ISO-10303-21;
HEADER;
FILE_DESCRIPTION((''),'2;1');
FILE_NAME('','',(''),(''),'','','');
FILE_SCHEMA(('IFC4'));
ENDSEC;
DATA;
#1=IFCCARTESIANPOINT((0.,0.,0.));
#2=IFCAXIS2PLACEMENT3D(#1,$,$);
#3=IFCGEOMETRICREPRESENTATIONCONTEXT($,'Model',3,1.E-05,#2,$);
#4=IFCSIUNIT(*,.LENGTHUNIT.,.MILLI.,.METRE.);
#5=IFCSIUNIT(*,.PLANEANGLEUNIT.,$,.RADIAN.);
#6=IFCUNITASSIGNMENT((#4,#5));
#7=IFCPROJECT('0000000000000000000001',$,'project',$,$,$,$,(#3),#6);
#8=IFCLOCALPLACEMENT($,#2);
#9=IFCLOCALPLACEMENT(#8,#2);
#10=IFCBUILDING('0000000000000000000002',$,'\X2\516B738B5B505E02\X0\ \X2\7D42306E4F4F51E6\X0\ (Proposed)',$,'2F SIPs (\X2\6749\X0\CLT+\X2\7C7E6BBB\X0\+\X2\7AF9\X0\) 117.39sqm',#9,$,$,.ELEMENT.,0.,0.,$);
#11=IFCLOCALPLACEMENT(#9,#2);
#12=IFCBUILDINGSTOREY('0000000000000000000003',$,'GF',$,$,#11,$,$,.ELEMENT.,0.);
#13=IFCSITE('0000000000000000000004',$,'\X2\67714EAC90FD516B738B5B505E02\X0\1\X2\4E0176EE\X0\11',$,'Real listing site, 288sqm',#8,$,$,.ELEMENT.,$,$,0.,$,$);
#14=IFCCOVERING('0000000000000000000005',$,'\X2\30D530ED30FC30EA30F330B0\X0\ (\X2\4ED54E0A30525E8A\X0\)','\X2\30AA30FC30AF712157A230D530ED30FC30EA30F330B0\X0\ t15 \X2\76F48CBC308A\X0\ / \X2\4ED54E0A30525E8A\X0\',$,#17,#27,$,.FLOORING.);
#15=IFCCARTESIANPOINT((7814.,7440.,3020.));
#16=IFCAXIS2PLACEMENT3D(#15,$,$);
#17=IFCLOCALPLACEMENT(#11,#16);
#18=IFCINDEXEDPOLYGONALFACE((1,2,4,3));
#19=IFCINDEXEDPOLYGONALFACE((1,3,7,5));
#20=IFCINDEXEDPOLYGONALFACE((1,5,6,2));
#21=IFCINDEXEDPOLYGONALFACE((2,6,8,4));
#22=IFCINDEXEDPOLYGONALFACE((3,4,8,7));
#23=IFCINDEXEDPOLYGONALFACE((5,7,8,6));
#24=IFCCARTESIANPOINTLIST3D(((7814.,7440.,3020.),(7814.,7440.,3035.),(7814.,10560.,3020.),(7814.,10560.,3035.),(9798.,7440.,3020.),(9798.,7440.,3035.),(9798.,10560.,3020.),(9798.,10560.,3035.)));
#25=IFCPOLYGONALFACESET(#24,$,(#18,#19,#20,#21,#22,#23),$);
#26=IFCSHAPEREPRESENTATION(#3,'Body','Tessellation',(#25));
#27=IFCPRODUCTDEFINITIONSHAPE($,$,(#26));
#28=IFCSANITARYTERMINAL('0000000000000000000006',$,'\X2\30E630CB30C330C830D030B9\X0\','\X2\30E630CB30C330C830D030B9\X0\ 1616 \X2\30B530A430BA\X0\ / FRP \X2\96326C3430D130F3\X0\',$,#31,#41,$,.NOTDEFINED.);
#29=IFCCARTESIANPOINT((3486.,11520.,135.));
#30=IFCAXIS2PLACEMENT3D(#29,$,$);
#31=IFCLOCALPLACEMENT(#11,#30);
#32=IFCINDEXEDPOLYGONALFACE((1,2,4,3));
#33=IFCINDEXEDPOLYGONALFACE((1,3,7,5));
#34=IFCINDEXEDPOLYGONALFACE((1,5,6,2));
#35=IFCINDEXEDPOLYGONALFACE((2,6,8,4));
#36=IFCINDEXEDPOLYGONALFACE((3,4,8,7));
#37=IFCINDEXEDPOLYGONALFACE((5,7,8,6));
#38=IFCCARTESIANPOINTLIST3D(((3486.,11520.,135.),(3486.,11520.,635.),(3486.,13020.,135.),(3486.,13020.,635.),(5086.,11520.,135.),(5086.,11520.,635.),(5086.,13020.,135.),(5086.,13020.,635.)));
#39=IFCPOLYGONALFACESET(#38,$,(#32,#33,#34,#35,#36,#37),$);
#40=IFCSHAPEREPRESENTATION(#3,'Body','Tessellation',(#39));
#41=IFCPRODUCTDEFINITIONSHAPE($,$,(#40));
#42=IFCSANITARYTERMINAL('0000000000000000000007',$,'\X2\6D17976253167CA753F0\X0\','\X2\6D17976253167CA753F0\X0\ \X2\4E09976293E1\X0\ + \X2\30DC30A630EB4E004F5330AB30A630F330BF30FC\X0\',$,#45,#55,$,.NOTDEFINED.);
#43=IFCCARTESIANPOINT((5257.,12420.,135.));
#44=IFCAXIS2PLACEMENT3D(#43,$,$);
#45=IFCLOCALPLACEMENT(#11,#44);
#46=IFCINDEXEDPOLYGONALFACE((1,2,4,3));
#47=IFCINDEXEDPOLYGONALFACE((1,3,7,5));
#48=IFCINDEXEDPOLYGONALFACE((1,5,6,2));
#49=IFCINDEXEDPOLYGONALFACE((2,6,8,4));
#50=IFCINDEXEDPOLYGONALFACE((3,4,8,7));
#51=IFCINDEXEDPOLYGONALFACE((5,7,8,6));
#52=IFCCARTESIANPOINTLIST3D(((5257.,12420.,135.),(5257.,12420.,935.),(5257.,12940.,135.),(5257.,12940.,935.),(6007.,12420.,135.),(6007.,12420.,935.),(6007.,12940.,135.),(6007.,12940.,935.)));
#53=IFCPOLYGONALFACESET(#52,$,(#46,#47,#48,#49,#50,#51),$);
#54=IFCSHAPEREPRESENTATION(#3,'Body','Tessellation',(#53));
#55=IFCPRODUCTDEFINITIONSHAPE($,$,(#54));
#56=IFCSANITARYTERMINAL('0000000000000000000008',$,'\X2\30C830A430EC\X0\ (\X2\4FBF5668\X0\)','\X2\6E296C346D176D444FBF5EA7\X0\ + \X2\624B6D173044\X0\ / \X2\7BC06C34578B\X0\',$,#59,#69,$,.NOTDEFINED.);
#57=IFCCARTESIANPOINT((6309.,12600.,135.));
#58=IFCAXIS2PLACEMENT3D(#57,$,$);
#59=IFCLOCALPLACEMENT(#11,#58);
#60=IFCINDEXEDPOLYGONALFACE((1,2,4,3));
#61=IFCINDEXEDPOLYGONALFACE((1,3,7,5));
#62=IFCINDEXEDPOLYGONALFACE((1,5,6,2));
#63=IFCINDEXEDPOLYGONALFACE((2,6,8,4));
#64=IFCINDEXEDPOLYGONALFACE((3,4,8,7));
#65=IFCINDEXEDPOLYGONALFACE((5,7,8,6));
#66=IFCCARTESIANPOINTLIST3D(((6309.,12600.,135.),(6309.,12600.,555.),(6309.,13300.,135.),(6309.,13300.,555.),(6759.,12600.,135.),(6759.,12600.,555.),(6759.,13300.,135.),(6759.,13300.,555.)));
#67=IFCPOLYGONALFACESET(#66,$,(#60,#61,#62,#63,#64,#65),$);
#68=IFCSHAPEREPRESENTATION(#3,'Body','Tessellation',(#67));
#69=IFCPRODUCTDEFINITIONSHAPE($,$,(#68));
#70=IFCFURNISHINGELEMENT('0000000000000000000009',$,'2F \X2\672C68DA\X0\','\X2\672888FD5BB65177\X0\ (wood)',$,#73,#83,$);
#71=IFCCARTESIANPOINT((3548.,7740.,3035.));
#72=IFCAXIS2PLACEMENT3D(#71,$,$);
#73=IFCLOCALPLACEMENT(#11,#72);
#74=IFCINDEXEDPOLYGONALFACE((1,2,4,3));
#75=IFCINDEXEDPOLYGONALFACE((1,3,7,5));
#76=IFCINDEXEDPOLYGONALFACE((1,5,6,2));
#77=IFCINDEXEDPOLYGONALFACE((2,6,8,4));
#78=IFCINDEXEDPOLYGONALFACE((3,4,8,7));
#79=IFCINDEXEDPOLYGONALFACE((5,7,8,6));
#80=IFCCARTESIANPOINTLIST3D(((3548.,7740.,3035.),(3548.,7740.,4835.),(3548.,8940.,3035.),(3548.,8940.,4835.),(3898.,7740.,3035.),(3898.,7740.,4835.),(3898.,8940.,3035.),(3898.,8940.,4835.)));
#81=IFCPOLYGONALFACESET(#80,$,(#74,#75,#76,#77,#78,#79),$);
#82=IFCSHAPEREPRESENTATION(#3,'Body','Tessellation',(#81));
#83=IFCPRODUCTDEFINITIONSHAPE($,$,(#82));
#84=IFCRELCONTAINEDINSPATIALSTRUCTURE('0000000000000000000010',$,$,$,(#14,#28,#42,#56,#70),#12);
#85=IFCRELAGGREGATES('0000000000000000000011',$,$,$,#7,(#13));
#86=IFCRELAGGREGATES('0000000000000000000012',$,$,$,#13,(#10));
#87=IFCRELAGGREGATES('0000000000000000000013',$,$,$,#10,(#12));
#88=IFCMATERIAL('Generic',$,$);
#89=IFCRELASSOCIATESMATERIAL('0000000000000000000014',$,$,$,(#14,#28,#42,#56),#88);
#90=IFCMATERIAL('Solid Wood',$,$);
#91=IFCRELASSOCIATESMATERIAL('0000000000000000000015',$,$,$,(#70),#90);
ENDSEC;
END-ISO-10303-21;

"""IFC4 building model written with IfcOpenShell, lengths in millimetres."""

from ifc_helpers import new_model, si_unit, frame, frame_2d, origin, place, context, project, spatial, rectangle, extrude, material, element, save


model = new_model("IFC4")

# Units and contexts
model_context = context("Model", 3, precision=1e-05, world=origin())
ifc_project = project(units=[si_unit("LENGTHUNIT", "METRE", prefix="MILLI"), si_unit("PLANEANGLEUNIT", "RADIAN")], contexts=[model_context])

# Site, building, storey
site_placement = place(None, origin())
site = spatial("IfcSite", under=ifc_project, at=site_placement, Name="東京都八王子市1丁目11", ObjectType="Real listing site, 288sqm", CompositionType="ELEMENT", RefElevation=0.0)
building_placement = place(site_placement, origin())
building = spatial("IfcBuilding", under=site, at=building_placement, Name="八王子市 終の住処 (Proposed)", ObjectType="2F SIPs (杉CLT+籾殻+竹) 117.39sqm", CompositionType="ELEMENT", ElevationOfRefHeight=0.0, ElevationOfTerrain=0.0)
storey_placement = place(building_placement, origin())
storey = spatial("IfcBuildingStorey", under=building, at=storey_placement, Name="GF", CompositionType="ELEMENT", Elevation=0.0)

# Shared definitions
ifc_material_1 = material(Name="Solid Wood")

# Shared definitions
ifc_material_2 = material(Name="Generic")

# Covering
covering_1_placement = place(storey_placement, frame((7814.0, 7440.0, 3020.0)))
element("IfcCovering", 1, at=covering_1_placement, inside=storey, material=ifc_material_2, Name="フローリング (仕上げ床)", Description="オーク無垢フローリング t15 直貼り / 仕上げ床", PredefinedType="FLOORING", context=model_context, shape_type="SweptSolid", body=[
    extrude(rectangle(XDim=1984.0, YDim=3120.0, at=frame_2d((992.0, 1560.0))), frame((7814.0, 7440.0, 3020.0)), (0.0, 0.0, 1.0), 15.0),
])

# Sanitary terminals
sanitary_terminal_1_placement = place(storey_placement, frame((3486.0, 11520.0, 135.0)))
element("IfcSanitaryTerminal", 2, at=sanitary_terminal_1_placement, inside=storey, material=ifc_material_2, Name="ユニットバス", Description="ユニットバス 1616 サイズ / FRP 防水パン", PredefinedType="NOTDEFINED", context=model_context, shape_type="SweptSolid", body=[
    extrude(rectangle(XDim=1600.0, YDim=1500.0, at=frame_2d((800.0, 750.0))), frame((3486.0, 11520.0, 135.0)), (0.0, 0.0, 1.0), 500.0),
])
sanitary_terminal_2_placement = place(storey_placement, frame((5257.0, 12420.0, 135.0)))
element("IfcSanitaryTerminal", 3, at=sanitary_terminal_2_placement, inside=storey, material=ifc_material_2, Name="洗面化粧台", Description="洗面化粧台 三面鏡 + ボウル一体カウンター", PredefinedType="NOTDEFINED", context=model_context, shape_type="SweptSolid", body=[
    extrude(rectangle(XDim=750.0, YDim=520.0, at=frame_2d((375.0, 260.0))), frame((5257.0, 12420.0, 135.0)), (0.0, 0.0, 1.0), 800.0),
])
sanitary_terminal_3_placement = place(storey_placement, frame((6309.0, 12600.0, 135.0)))
element("IfcSanitaryTerminal", 4, at=sanitary_terminal_3_placement, inside=storey, material=ifc_material_2, Name="トイレ (便器)", Description="温水洗浄便座 + 手洗い / 節水型", PredefinedType="NOTDEFINED", context=model_context, shape_type="SweptSolid", body=[
    extrude(rectangle(XDim=450.0, YDim=700.0, at=frame_2d((225.0, 350.0))), frame((6309.0, 12600.0, 135.0)), (0.0, 0.0, 1.0), 420.0),
])

# Furnishing element
furnishing_placement = place(storey_placement, frame((3548.0, 7740.0, 3035.0)))
element("IfcFurnishingElement", 5, at=furnishing_placement, inside=storey, material=ifc_material_1, Name="2F 本棚", Description="木製家具 (wood)", context=model_context, shape_type="SweptSolid", body=[
    extrude(rectangle(XDim=350.0, YDim=1200.0, at=frame_2d((175.0, 600.0))), frame((3548.0, 7740.0, 3035.0)), (0.0, 0.0, 1.0), 1800.0),
])

save(model, "model.ifc")
